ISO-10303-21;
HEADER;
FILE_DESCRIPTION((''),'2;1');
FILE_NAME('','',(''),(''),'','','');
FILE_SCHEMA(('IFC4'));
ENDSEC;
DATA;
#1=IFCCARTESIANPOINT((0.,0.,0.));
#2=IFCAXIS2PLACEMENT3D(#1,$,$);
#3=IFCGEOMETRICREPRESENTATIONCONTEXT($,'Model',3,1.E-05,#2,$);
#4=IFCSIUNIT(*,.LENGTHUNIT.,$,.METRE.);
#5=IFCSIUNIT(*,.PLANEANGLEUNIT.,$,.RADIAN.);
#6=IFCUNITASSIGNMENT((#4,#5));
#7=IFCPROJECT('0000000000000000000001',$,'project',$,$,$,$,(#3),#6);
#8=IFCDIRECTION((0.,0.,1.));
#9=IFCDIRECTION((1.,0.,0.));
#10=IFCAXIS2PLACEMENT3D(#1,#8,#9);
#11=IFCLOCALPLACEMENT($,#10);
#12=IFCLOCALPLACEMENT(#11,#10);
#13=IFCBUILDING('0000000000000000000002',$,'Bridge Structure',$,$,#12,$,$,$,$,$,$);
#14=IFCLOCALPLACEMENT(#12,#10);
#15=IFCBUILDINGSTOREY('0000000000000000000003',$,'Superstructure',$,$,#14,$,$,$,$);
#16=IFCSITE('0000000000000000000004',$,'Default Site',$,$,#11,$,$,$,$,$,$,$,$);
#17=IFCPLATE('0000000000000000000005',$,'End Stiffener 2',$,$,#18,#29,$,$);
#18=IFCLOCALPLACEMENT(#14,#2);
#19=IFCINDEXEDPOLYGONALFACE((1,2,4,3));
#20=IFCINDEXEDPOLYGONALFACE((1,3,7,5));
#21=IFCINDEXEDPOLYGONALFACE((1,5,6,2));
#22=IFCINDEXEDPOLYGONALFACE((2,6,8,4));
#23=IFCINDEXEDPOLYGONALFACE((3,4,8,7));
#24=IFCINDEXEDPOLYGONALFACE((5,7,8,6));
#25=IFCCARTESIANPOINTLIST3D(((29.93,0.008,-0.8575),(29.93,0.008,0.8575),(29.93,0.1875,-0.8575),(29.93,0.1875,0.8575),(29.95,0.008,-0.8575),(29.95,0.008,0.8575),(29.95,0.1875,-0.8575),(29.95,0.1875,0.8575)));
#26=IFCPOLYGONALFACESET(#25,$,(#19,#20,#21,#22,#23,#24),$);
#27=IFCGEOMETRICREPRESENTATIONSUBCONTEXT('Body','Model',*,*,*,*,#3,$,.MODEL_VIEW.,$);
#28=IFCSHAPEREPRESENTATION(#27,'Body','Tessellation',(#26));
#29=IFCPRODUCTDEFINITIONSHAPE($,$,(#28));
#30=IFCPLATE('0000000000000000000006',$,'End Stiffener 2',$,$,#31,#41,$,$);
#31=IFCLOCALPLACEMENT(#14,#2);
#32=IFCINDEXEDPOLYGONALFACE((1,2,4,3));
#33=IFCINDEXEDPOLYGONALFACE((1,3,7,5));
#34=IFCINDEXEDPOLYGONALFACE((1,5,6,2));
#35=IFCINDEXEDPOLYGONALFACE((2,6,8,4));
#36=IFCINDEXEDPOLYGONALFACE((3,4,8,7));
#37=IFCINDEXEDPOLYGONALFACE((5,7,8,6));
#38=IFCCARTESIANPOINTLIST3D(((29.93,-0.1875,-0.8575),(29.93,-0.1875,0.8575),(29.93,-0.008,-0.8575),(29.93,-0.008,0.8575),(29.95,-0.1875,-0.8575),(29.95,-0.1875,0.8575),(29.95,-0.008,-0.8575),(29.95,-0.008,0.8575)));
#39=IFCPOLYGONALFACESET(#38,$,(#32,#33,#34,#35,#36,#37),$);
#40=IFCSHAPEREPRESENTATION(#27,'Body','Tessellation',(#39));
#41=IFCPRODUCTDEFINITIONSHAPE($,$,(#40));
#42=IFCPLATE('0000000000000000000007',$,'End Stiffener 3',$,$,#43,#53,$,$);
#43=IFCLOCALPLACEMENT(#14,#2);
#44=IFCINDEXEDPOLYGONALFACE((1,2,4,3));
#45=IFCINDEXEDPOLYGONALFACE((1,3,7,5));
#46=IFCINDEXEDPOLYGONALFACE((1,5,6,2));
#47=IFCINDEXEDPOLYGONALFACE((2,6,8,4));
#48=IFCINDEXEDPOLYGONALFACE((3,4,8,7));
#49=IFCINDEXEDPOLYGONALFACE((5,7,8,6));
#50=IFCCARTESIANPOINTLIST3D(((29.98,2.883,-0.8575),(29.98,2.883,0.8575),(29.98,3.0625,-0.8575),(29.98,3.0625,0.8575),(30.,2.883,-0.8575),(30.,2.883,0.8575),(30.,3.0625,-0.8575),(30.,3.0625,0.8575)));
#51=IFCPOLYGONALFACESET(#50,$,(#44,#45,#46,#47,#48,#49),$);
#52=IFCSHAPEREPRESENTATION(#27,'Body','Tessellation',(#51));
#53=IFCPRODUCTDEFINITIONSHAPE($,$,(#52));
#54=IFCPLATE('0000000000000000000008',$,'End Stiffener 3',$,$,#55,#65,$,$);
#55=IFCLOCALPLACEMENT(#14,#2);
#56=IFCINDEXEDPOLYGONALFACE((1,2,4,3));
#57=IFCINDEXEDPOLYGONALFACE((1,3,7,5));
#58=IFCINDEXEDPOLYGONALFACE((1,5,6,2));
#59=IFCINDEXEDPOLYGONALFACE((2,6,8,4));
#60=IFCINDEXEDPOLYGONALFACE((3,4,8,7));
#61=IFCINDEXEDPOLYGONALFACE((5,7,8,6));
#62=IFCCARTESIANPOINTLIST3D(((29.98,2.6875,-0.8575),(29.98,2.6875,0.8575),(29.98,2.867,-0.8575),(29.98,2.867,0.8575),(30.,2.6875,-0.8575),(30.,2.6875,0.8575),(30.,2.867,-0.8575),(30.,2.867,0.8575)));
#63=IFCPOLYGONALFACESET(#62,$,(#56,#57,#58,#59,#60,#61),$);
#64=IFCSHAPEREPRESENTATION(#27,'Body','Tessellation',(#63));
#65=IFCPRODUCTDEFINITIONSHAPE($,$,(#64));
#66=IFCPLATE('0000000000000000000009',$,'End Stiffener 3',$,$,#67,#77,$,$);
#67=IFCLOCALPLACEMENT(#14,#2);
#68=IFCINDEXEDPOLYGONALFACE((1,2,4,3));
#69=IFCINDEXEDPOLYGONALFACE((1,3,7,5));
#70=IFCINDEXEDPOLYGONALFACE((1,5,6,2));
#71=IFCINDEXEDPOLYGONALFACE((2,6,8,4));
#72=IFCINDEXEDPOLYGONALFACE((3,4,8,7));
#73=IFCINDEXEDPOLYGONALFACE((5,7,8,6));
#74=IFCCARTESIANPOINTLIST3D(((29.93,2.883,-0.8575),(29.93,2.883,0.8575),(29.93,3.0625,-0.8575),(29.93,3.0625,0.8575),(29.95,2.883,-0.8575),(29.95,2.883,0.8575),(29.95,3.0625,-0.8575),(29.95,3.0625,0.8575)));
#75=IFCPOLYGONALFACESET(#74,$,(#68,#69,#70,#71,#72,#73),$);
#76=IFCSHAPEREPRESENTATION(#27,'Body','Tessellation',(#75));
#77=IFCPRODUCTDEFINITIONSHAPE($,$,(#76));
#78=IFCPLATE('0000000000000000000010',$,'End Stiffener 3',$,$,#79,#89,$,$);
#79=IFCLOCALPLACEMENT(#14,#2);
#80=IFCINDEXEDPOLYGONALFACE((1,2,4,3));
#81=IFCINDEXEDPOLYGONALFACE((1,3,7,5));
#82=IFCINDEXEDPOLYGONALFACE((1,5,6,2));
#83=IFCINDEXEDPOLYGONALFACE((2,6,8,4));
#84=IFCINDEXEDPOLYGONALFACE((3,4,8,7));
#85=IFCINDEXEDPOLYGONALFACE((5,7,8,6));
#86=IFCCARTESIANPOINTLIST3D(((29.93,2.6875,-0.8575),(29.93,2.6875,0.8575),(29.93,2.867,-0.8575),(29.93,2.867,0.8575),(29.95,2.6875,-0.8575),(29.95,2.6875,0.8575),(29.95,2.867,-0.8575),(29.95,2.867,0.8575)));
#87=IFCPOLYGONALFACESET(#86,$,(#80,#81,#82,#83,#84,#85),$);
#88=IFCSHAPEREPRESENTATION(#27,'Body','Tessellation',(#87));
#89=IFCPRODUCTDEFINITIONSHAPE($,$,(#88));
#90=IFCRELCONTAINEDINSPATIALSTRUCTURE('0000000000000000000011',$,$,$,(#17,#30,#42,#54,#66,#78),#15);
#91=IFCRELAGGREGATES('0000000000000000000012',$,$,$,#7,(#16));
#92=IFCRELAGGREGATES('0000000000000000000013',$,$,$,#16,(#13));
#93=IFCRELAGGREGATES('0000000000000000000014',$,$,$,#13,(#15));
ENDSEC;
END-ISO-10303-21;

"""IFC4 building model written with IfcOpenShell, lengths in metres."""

from ifc_helpers import new_model, si_unit, frame, origin, origin_with_axes, origin_2d_with_axis, place, context, subcontext, project, spatial, rectangle, extrude, element, save


model = new_model("IFC4")

# Units and contexts
model_context = context("Model", 3, precision=1e-05, world=origin())
body_context = subcontext(model_context, "Body", "Model", "MODEL_VIEW")
ifc_project = project(units=[si_unit("LENGTHUNIT", "METRE"), si_unit("PLANEANGLEUNIT", "RADIAN")], contexts=[model_context])

# Site, building, storey
site_placement = place(None, origin_with_axes())
site = spatial("IfcSite", under=ifc_project, at=site_placement, Name="Default Site")
building_placement = place(site_placement, origin_with_axes())
building = spatial("IfcBuilding", under=site, at=building_placement, Name="Bridge Structure")
storey_placement = place(building_placement, origin_with_axes())
storey = spatial("IfcBuildingStorey", under=building, at=storey_placement, Name="Superstructure")

# Plates
for number, where, z_axis, x_axis, name in (
    (1, (29.94, 0.0978, -0.8575), (0.0, 0.0, 1.0), (1.0, 0.0, 0.0), "End Stiffener 2"),
    (2, (29.94, -0.0978, -0.8575), (0.0, 0.0, 1.0), (1.0, 0.0, 0.0), "End Stiffener 2"),
    (3, (29.99, 2.9728, -0.8575), (0.0, 0.0, 1.0), (1.0, 0.0, 0.0), "End Stiffener 3"),
    (4, (29.99, 2.7772, -0.8575), (0.0, 0.0, 1.0), (1.0, 0.0, 0.0), "End Stiffener 3"),
    (5, (29.94, 2.9728, -0.8575), (0.0, 0.0, 1.0), (1.0, 0.0, 0.0), "End Stiffener 3"),
    (6, (29.94, 2.7772, -0.8575), (0.0, 0.0, 1.0), (1.0, 0.0, 0.0), "End Stiffener 3"),
):
    element("IfcPlate", number, at=place(storey_placement, frame(where, z_axis=z_axis, x_axis=x_axis)), inside=storey, Name=name, context=body_context, shape_type="SweptSolid", body=[
        extrude(rectangle(XDim=0.02, YDim=0.1795, at=origin_2d_with_axis()), origin_with_axes(), (0.0, 0.0, 1.0), 1.715),
    ])

save(model, "model.ifc")
